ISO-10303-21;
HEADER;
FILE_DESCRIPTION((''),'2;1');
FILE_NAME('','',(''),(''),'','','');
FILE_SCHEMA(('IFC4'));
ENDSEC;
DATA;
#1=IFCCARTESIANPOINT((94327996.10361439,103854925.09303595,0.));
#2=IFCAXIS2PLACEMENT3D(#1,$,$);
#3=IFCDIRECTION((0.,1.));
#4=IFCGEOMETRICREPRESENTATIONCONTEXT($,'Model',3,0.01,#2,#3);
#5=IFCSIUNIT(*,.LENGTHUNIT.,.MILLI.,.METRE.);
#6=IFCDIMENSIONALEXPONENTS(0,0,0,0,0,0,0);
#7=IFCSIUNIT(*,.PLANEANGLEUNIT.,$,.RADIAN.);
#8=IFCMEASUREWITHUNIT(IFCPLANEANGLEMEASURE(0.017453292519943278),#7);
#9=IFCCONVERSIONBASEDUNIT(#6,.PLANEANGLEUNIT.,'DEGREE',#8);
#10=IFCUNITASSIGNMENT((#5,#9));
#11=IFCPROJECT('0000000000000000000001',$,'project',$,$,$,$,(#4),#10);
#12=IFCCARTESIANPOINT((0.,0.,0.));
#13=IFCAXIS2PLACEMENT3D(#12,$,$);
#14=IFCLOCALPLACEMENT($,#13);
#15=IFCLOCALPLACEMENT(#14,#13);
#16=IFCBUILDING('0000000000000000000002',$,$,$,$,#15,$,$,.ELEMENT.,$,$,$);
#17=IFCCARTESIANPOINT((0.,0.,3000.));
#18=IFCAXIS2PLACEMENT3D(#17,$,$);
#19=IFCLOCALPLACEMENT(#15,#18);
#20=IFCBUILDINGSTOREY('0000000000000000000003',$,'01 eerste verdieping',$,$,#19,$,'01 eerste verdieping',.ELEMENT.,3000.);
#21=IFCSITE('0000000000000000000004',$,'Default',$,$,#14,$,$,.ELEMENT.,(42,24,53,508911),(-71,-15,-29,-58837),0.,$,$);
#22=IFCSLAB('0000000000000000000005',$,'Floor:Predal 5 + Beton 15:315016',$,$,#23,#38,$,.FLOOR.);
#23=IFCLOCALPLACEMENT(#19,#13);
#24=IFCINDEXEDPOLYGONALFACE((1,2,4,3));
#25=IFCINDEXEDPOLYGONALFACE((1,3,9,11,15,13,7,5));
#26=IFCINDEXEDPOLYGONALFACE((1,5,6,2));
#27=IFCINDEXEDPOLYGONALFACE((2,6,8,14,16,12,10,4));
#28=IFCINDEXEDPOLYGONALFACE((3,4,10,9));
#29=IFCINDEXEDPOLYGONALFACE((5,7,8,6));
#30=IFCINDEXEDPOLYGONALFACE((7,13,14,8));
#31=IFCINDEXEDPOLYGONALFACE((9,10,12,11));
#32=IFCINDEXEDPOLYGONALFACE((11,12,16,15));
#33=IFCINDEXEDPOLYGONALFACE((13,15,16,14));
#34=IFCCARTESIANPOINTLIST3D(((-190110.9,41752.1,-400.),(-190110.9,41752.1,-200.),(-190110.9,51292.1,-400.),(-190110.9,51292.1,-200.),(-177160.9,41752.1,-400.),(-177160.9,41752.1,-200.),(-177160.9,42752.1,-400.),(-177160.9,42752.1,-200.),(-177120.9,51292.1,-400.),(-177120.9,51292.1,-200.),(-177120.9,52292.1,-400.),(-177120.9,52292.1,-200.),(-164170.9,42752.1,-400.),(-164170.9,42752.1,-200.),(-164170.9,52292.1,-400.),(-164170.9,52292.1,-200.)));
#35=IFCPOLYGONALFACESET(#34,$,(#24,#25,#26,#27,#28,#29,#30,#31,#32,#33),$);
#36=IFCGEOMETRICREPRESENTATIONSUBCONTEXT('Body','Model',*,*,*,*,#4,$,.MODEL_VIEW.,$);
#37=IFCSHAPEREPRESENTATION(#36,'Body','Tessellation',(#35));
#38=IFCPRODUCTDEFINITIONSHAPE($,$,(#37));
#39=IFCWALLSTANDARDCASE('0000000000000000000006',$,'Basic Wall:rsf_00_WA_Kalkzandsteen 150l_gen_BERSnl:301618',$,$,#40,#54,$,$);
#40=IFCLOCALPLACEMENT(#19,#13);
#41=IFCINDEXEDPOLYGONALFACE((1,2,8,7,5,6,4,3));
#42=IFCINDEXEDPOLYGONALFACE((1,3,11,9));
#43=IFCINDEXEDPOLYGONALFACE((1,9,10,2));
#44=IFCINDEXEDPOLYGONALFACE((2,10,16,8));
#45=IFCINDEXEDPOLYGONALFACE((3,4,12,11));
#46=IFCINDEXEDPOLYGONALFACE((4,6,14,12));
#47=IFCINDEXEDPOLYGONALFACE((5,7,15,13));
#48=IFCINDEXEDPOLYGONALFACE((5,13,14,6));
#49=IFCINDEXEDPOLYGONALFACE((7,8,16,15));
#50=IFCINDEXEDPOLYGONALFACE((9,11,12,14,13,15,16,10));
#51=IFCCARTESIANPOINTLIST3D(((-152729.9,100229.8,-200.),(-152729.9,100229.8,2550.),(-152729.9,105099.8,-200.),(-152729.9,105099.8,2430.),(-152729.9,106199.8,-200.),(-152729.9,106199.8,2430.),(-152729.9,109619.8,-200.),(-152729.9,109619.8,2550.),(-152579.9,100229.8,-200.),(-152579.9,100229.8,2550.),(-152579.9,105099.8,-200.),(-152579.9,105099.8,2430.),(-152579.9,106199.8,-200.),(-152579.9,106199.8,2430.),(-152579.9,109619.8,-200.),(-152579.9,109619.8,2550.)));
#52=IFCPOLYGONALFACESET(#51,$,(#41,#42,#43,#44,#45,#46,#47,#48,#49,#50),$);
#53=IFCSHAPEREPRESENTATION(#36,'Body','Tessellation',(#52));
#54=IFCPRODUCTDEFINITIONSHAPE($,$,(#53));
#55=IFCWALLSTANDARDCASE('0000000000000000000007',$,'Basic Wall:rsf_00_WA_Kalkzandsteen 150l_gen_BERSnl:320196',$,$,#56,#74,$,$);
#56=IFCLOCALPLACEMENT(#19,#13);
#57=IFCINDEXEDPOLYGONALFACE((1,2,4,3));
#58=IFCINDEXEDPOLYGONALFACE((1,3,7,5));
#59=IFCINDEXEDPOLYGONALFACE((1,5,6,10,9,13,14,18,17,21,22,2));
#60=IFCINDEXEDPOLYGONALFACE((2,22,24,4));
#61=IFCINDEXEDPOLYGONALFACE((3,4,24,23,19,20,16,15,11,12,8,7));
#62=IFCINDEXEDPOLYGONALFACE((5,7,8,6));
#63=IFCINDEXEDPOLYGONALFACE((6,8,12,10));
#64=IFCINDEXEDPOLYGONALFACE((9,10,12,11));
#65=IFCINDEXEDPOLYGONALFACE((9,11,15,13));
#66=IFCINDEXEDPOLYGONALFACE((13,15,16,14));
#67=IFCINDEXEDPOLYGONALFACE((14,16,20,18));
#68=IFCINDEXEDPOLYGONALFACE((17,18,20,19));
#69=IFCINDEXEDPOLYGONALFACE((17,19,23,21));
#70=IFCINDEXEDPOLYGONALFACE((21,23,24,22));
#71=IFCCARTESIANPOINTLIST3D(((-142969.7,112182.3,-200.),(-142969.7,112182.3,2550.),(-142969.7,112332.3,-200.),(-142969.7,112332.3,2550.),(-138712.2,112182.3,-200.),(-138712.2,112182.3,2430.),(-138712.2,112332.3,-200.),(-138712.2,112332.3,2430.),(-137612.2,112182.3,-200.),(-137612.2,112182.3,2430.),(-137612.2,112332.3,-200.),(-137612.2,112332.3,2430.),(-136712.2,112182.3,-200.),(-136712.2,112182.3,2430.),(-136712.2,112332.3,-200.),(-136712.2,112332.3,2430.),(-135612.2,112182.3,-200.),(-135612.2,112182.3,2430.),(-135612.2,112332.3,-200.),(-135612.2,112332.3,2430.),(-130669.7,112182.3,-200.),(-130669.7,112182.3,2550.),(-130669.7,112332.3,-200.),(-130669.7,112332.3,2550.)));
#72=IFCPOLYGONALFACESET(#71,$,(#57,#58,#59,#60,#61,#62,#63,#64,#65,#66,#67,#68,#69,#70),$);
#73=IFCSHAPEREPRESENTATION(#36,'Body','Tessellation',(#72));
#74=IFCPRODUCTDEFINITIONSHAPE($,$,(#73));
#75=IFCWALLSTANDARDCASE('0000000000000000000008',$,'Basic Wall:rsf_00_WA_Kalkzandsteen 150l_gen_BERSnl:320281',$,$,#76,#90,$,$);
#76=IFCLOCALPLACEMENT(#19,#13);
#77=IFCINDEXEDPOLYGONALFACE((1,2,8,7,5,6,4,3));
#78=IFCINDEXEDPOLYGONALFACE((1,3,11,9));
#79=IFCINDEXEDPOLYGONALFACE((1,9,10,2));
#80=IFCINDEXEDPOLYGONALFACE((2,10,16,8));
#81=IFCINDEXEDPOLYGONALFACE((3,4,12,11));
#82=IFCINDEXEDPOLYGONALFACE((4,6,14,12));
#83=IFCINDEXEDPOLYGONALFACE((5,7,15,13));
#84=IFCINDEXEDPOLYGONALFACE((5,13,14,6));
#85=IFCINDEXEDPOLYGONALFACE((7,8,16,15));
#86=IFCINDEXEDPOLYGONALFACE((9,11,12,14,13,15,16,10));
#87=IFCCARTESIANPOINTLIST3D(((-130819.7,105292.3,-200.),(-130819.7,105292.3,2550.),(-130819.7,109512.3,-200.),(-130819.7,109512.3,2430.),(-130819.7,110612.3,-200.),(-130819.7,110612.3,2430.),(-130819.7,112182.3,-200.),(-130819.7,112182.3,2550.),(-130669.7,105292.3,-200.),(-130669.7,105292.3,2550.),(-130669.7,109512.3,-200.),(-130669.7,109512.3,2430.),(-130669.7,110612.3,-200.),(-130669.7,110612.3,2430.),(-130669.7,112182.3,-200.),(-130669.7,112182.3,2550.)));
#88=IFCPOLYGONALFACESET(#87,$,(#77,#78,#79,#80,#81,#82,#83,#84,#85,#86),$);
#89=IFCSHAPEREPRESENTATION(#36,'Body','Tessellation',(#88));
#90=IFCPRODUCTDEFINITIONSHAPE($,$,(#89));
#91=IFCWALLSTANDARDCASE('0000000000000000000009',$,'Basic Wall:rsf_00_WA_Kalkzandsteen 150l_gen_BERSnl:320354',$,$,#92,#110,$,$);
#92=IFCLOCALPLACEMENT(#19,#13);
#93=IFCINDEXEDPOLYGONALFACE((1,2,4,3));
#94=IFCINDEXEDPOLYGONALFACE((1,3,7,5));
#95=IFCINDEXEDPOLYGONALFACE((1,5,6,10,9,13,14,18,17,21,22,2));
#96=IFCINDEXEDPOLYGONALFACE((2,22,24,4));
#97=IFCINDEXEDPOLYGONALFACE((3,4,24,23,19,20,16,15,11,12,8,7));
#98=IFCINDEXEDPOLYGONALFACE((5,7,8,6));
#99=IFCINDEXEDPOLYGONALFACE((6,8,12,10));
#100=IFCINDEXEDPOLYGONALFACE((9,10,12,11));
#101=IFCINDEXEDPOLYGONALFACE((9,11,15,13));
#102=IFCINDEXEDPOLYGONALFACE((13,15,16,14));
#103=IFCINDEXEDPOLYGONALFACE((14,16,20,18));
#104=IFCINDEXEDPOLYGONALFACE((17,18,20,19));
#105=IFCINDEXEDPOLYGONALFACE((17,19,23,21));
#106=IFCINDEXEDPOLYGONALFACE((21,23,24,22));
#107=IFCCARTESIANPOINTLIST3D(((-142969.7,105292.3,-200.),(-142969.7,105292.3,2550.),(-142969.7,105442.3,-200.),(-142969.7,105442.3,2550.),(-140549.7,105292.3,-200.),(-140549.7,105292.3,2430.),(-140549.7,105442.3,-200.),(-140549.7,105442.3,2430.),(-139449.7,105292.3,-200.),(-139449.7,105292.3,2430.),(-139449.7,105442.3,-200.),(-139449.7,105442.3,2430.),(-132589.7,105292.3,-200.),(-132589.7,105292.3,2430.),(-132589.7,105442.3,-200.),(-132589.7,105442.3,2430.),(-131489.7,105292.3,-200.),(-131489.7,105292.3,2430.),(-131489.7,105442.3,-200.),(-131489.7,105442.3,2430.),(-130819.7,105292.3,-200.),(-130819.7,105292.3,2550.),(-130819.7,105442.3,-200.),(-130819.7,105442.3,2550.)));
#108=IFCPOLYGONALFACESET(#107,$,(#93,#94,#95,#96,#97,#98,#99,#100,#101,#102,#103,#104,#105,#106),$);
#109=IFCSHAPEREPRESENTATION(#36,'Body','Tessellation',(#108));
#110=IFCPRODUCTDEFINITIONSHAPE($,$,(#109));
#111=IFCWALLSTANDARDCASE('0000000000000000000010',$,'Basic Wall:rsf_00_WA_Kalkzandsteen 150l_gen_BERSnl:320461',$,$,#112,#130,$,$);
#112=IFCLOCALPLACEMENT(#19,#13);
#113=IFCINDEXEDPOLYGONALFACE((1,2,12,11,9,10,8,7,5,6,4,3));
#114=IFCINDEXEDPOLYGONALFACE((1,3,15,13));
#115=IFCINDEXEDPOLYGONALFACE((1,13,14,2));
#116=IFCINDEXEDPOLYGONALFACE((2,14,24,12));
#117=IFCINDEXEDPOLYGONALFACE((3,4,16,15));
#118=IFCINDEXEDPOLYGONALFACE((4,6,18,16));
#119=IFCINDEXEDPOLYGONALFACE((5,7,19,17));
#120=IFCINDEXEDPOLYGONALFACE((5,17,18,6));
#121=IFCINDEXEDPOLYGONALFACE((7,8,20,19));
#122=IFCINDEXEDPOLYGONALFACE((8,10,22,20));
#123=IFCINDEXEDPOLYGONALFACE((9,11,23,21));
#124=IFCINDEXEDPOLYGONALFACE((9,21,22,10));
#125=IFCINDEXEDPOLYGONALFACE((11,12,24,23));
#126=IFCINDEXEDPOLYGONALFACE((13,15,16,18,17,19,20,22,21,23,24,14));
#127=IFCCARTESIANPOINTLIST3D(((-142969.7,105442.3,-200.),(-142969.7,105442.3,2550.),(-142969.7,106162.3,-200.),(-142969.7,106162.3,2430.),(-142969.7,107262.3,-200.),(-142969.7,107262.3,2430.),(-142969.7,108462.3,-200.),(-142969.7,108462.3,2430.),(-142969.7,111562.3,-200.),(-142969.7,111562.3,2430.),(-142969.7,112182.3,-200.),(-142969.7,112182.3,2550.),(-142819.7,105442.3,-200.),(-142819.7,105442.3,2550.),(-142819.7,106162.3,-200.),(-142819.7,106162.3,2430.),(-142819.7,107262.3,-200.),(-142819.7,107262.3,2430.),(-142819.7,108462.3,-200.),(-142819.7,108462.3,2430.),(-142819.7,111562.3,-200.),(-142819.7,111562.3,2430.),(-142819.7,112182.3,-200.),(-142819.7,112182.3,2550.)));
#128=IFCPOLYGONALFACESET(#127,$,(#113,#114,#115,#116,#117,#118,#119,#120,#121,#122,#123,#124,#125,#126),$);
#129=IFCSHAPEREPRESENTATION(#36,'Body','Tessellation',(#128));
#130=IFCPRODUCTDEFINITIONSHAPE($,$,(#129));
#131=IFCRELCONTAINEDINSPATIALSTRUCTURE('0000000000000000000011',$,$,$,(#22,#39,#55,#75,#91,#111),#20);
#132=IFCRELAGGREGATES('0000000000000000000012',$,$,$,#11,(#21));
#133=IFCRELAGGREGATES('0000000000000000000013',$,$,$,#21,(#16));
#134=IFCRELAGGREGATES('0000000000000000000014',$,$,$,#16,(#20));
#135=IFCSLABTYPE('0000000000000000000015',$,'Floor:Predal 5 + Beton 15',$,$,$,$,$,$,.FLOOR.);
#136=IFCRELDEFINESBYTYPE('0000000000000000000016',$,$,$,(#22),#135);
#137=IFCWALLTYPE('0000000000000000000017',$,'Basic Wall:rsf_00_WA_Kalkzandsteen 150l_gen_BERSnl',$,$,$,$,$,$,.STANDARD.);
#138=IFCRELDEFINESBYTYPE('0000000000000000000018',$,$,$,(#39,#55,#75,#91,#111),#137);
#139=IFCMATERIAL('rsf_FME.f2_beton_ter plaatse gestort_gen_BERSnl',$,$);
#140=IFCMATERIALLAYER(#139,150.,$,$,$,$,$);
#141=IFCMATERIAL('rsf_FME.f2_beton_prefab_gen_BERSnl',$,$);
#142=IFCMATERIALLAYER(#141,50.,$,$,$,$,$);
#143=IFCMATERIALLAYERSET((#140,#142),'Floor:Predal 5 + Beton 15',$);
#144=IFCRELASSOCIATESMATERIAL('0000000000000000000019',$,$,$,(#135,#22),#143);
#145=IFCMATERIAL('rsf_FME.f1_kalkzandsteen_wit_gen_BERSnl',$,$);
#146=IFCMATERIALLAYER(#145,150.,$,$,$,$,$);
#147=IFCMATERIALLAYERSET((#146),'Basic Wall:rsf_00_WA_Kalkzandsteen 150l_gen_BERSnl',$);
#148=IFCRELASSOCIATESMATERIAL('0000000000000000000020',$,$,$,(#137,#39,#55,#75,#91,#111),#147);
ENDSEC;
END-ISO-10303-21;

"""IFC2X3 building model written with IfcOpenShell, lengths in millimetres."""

from ifc_helpers import new_model, entity, si_unit, converted_unit, direction, frame, frame_2d, origin, place, context, subcontext, project, spatial, polyline, rectangle, outline, extrude, clip, bounded_halfspace, material, layer, layer_set, layer_usage, type_object, element, save


model = new_model("IFC2X3")

# Units and contexts
model_context = context("Model", 3, precision=0.01, world=frame((94327996.10361439, 103854925.09303595, 0.0)), true_north=direction((0.0, 1.0)))
body_context = subcontext(model_context, "Body", "Model", "MODEL_VIEW")
ifc_project = project(units=[si_unit("LENGTHUNIT", "METRE", prefix="MILLI"), converted_unit("PLANEANGLEUNIT", "DEGREE", entity("IfcPlaneAngleMeasure", 0.017453292519943278), si_unit("PLANEANGLEUNIT", "RADIAN"), dimensions=[0, 0, 0, 0, 0, 0, 0])], contexts=[model_context])

# Site, building, storey
site_placement = place(None, origin())
site = spatial("IfcSite", under=ifc_project, at=site_placement, Name="Default", CompositionType="ELEMENT", RefLatitude=(42, 24, 53, 508911), RefLongitude=(-71, -15, -29, -58837), RefElevation=0.0)
building_placement = place(site_placement, origin())
building = spatial("IfcBuilding", under=site, at=building_placement, CompositionType="ELEMENT")
storey_placement = place(building_placement, frame((0.0, 0.0, 3000.0)))
storey = spatial("IfcBuildingStorey", under=building, at=storey_placement, Name="01 eerste verdieping", LongName="01 eerste verdieping", CompositionType="ELEMENT", Elevation=3000.0)

# Slab
ifc_material_1 = material(Name="rsf_FME.f2_beton_ter plaatse gestort_gen_BERSnl")
ifc_layer_1 = layer(ifc_material_1, 150.0)
ifc_material_2 = material(Name="rsf_FME.f2_beton_prefab_gen_BERSnl")
ifc_layer_2 = layer(ifc_material_2, 50.0)
ifc_layer_set_1 = layer_set([ifc_layer_1, ifc_layer_2], Name="Floor:Predal 5 + Beton 15")
slab_type_1 = type_object("IfcSlabType", Name="Floor:Predal 5 + Beton 15", PredefinedType="FLOOR", material=ifc_layer_set_1)
ifc_layer_usage_1 = layer_usage(ifc_layer_set_1, "AXIS3", "POSITIVE", 0.0)
slab_1_placement = place(storey_placement, origin())
element("IfcSlab", 1, at=slab_1_placement, inside=storey, type_object=slab_type_1, material=ifc_layer_usage_1, Name="Floor:Predal 5 + Beton 15:315016", PredefinedType="FLOOR", context=body_context, shape_type="SweptSolid", body=[
    extrude(outline(polyline([(-5270.0, -12970.0), (4270.0, -12970.0), (4270.0, 20.0), (5270.0, 20.0), (5270.0, 12970.0), (-4270.0, 12970.0), (-4270.0, -20.0), (-5270.0, -20.0), (-5270.0, -12970.0)])), frame((-177140.9, 47022.1, -200.0), z_axis=(0.0, 0.0, -1.0), x_axis=(0.0, 1.0, 0.0)), (0.0, 0.0, 1.0), 200.0),
])

# Wall, opening
ifc_material_3 = material(Name="rsf_FME.f1_kalkzandsteen_wit_gen_BERSnl")
ifc_layer_3 = layer(ifc_material_3, 150.0)
ifc_layer_set_2 = layer_set([ifc_layer_3], Name="Basic Wall:rsf_00_WA_Kalkzandsteen 150l_gen_BERSnl")
ifc_layer_usage_2 = layer_usage(ifc_layer_set_2, "AXIS2", "NEGATIVE", 75.0)
wall_type = type_object("IfcWallType", Name="Basic Wall:rsf_00_WA_Kalkzandsteen 150l_gen_BERSnl", PredefinedType="STANDARD", material=ifc_layer_set_2)
wall_1_placement = place(storey_placement, frame((-152654.9, 100229.8, -200.0), z_axis=(0.0, 0.0, 1.0), x_axis=(0.0, 1.0, 0.0)))
wall_1 = element("IfcWallStandardCase", 2, at=wall_1_placement, inside=storey, type_object=wall_type, material=ifc_layer_usage_2, Name="Basic Wall:rsf_00_WA_Kalkzandsteen 150l_gen_BERSnl:301618", context=body_context, shape_type="Clipping", body=[
    clip(extrude(rectangle(XDim=9390.0, YDim=150.0, at=frame_2d((4695.0, 0.0), x_axis=(-1.0, 0.0))), origin(), (0.0, 0.0, 1.0), 2750.0), bounded_halfspace(frame((0.0, -75.0, 2750.0), z_axis=(0.0, 0.0, -1.0), x_axis=(1.0, 0.0, 0.0)), True, frame((0.0, -75.0, 2750.0)), polyline([(0.0, 0.0), (9390.0, 0.0), (9390.0, 150.0), (9240.0, 150.0), (0.0, 150.0), (0.0, 0.0)]))),
])
opening_1_placement = place(wall_1_placement, frame((-100229.8, -152654.9, 200.0), z_axis=(0.0, 0.0, 1.0), x_axis=(0.0, -1.0, 0.0)))
element("IfcOpeningElement", 3, at=opening_1_placement, cuts=wall_1, ObjectType="Opening", context=body_context, shape_type="SweptSolid", body=[
    extrude(rectangle(XDim=2630.0, YDim=1100.0, at=frame_2d((0.0, 0.0), x_axis=(1.0, 0.0))), frame((-151205.9, 105649.8, 1115.0), z_axis=(-1.0, 0.0, 0.0), x_axis=(0.0, 0.0, 1.0)), (0.0, 0.0, 1.0), 3048.0),
])

# Wall, openings
ifc_layer_usage_3 = layer_usage(ifc_layer_set_2, "AXIS2", "POSITIVE", -75.0)
wall_2_placement = place(storey_placement, frame((-142969.7, 112257.3, -200.0)))
wall_2 = element("IfcWallStandardCase", 4, at=wall_2_placement, inside=storey, type_object=wall_type, material=ifc_layer_usage_3, Name="Basic Wall:rsf_00_WA_Kalkzandsteen 150l_gen_BERSnl:320196", context=body_context, shape_type="Clipping", body=[
    clip(extrude(rectangle(XDim=12300.0, YDim=150.0, at=frame_2d((6150.0, 0.0), x_axis=(-1.0, 0.0))), origin(), (0.0, 0.0, 1.0), 2750.0), bounded_halfspace(frame((0.0, -75.0, 2750.0), z_axis=(0.0, 0.0, -1.0), x_axis=(1.0, 0.0, 0.0)), True, frame((0.0, -75.0, 2750.0)), polyline([(0.0, 0.0), (150.0, 0.0), (7790.0, 0.0), (7940.0, 0.0), (12150.0, 0.0), (12300.0, 0.0), (12300.0, 150.0), (0.0, 150.0), (0.0, 0.0)]))),
])
opening_2_placement = place(wall_2_placement, frame((142969.7, -112257.3, 200.0)))
element("IfcOpeningElement", 5, at=opening_2_placement, cuts=wall_2, ObjectType="Opening", context=body_context, shape_type="SweptSolid", body=[
    extrude(rectangle(XDim=2630.0, YDim=1100.0, at=frame_2d((0.0, 0.0), x_axis=(1.0, 0.0))), frame((-136162.2, 110808.3, 1115.0), z_axis=(0.0, 1.0, 0.0), x_axis=(0.0, 0.0, 1.0)), (0.0, 0.0, 1.0), 3048.0),
])
opening_3_placement = place(wall_2_placement, frame((142969.7, -112257.3, 200.0)))
element("IfcOpeningElement", 6, at=opening_3_placement, cuts=wall_2, ObjectType="Opening", context=body_context, shape_type="SweptSolid", body=[
    extrude(rectangle(XDim=2630.0, YDim=1100.0, at=frame_2d((0.0, 0.0), x_axis=(1.0, 0.0))), frame((-138162.2, 110808.3, 1115.0), z_axis=(0.0, 1.0, 0.0), x_axis=(0.0, 0.0, 1.0)), (0.0, 0.0, 1.0), 3048.0),
])

# Wall, opening
ifc_layer_usage_4 = layer_usage(ifc_layer_set_2, "AXIS2", "POSITIVE", -75.0)
wall_3_placement = place(storey_placement, frame((-130744.7, 112182.3, -200.0), z_axis=(0.0, 0.0, 1.0), x_axis=(0.0, -1.0, 0.0)))
wall_3 = element("IfcWallStandardCase", 7, at=wall_3_placement, inside=storey, type_object=wall_type, material=ifc_layer_usage_4, Name="Basic Wall:rsf_00_WA_Kalkzandsteen 150l_gen_BERSnl:320281", context=body_context, shape_type="Clipping", body=[
    clip(extrude(rectangle(XDim=6890.0, YDim=150.0, at=frame_2d((3445.0, 0.0), x_axis=(1.0, 0.0))), origin(), (0.0, 0.0, 1.0), 2750.0), bounded_halfspace(frame((0.0, -75.0, 2750.0), z_axis=(0.0, 0.0, -1.0), x_axis=(0.0, 1.0, 0.0)), True, frame((0.0, -75.0, 2750.0)), polyline([(0.0, 0.0), (6740.0, 0.0), (6890.0, 0.0), (6890.0, 150.0), (0.0, 150.0), (0.0, 0.0)]))),
])
opening_4_placement = place(wall_3_placement, frame((112182.3, 130744.7, 200.0), z_axis=(0.0, 0.0, 1.0), x_axis=(0.0, 1.0, 0.0)))
element("IfcOpeningElement", 8, at=opening_4_placement, cuts=wall_3, ObjectType="Opening", context=body_context, shape_type="SweptSolid", body=[
    extrude(rectangle(XDim=2630.0, YDim=1100.0, at=frame_2d((0.0, 0.0), x_axis=(0.0, 1.0))), frame((-132343.7, 110062.3, 1115.0), z_axis=(1.0, 0.0, 0.0), x_axis=(0.0, 1.0, 0.0)), (0.0, 0.0, 1.0), 3048.0),
])

# Walls, openings
ifc_layer_usage_5 = layer_usage(ifc_layer_set_2, "AXIS2", "POSITIVE", -75.0)
wall_4_placement = place(storey_placement, frame((-130819.7, 105367.3, -200.0), z_axis=(0.0, 0.0, 1.0), x_axis=(-1.0, 0.0, 0.0)))
wall_4 = element("IfcWallStandardCase", 9, at=wall_4_placement, inside=storey, type_object=wall_type, material=ifc_layer_usage_5, Name="Basic Wall:rsf_00_WA_Kalkzandsteen 150l_gen_BERSnl:320354", context=body_context, shape_type="Clipping", body=[
    clip(extrude(rectangle(XDim=12150.0, YDim=150.0, at=frame_2d((6075.0, 0.0), x_axis=(1.0, 0.0))), origin(), (0.0, 0.0, 1.0), 2750.0), bounded_halfspace(frame((0.0, -75.0, 2750.0), z_axis=(0.0, 0.0, -1.0), x_axis=(-1.0, 0.0, 0.0)), True, frame((0.0, -75.0, 2750.0)), polyline([(0.0, 0.0), (4210.0, 0.0), (4360.0, 0.0), (7850.0, 0.0), (8000.0, 0.0), (12000.0, 0.0), (12150.0, 0.0), (12150.0, 150.0), (0.0, 150.0), (0.0, 0.0)]))),
])
opening_5_placement = place(wall_4_placement, frame((-130819.7, 105367.3, 200.0), z_axis=(0.0, 0.0, 1.0), x_axis=(-1.0, 0.0, 0.0)))
element("IfcOpeningElement", 10, at=opening_5_placement, cuts=wall_4, ObjectType="Opening", context=body_context, shape_type="SweptSolid", body=[
    extrude(rectangle(XDim=2630.0, YDim=1100.0, at=frame_2d((0.0, 0.0), x_axis=(0.0, 1.0))), frame((-139999.7, 106966.3, 1115.0), z_axis=(0.0, -1.0, 0.0), x_axis=(1.0, 0.0, 0.0)), (0.0, 0.0, 1.0), 3048.0),
])
opening_6_placement = place(wall_4_placement, frame((-130819.7, 105367.3, 200.0), z_axis=(0.0, 0.0, 1.0), x_axis=(-1.0, 0.0, 0.0)))
element("IfcOpeningElement", 11, at=opening_6_placement, cuts=wall_4, ObjectType="Opening", context=body_context, shape_type="SweptSolid", body=[
    extrude(rectangle(XDim=2630.0, YDim=1100.0, at=frame_2d((0.0, 0.0), x_axis=(1.0, 0.0))), frame((-132039.7, 106816.3, 1115.0), z_axis=(0.0, -1.0, 0.0), x_axis=(0.0, 0.0, 1.0)), (0.0, 0.0, 1.0), 3048.0),
])
ifc_layer_usage_6 = layer_usage(ifc_layer_set_2, "AXIS2", "POSITIVE", -75.0)
wall_5_placement = place(storey_placement, frame((-142894.7, 105442.3, -200.0), z_axis=(0.0, 0.0, 1.0), x_axis=(0.0, 1.0, 0.0)))
wall_5 = element("IfcWallStandardCase", 12, at=wall_5_placement, inside=storey, type_object=wall_type, material=ifc_layer_usage_6, Name="Basic Wall:rsf_00_WA_Kalkzandsteen 150l_gen_BERSnl:320461", context=body_context, shape_type="Clipping", body=[
    clip(extrude(rectangle(XDim=6740.0, YDim=150.0, at=frame_2d((3370.0, 0.0), x_axis=(1.0, 0.0))), origin(), (0.0, 0.0, 1.0), 2750.0), bounded_halfspace(frame((0.0, -75.0, 2750.0), z_axis=(0.0, 0.0, -1.0), x_axis=(0.0, -1.0, 0.0)), True, frame((0.0, -75.0, 2750.0)), polyline([(0.0, 0.0), (6740.0, 0.0), (6740.0, 150.0), (0.0, 150.0), (0.0, 0.0)]))),
])
opening_7_placement = place(wall_5_placement, frame((-105442.3, -142894.7, 200.0), z_axis=(0.0, 0.0, 1.0), x_axis=(0.0, -1.0, 0.0)))
element("IfcOpeningElement", 13, at=opening_7_placement, cuts=wall_5, ObjectType="Opening", context=body_context, shape_type="SweptSolid", body=[
    extrude(rectangle(XDim=2630.0, YDim=3100.0, at=frame_2d((0.0, 0.0), x_axis=(0.0, 1.0))), frame((-141295.7, 110012.3, 1115.0), z_axis=(-1.0, 0.0, 0.0), x_axis=(0.0, -1.0, 0.0)), (0.0, 0.0, 1.0), 3048.0),
])
opening_8_placement = place(wall_5_placement, frame((-105442.3, -142894.7, 200.0), z_axis=(0.0, 0.0, 1.0), x_axis=(0.0, -1.0, 0.0)))
element("IfcOpeningElement", 14, at=opening_8_placement, cuts=wall_5, ObjectType="Opening", context=body_context, shape_type="SweptSolid", body=[
    extrude(rectangle(XDim=2630.0, YDim=1100.0, at=frame_2d((0.0, 0.0), x_axis=(0.0, 1.0))), frame((-141295.7, 106712.3, 1115.0), z_axis=(-1.0, 0.0, 0.0), x_axis=(0.0, -1.0, 0.0)), (0.0, 0.0, 1.0), 3048.0),
])

save(model, "model.ifc")
